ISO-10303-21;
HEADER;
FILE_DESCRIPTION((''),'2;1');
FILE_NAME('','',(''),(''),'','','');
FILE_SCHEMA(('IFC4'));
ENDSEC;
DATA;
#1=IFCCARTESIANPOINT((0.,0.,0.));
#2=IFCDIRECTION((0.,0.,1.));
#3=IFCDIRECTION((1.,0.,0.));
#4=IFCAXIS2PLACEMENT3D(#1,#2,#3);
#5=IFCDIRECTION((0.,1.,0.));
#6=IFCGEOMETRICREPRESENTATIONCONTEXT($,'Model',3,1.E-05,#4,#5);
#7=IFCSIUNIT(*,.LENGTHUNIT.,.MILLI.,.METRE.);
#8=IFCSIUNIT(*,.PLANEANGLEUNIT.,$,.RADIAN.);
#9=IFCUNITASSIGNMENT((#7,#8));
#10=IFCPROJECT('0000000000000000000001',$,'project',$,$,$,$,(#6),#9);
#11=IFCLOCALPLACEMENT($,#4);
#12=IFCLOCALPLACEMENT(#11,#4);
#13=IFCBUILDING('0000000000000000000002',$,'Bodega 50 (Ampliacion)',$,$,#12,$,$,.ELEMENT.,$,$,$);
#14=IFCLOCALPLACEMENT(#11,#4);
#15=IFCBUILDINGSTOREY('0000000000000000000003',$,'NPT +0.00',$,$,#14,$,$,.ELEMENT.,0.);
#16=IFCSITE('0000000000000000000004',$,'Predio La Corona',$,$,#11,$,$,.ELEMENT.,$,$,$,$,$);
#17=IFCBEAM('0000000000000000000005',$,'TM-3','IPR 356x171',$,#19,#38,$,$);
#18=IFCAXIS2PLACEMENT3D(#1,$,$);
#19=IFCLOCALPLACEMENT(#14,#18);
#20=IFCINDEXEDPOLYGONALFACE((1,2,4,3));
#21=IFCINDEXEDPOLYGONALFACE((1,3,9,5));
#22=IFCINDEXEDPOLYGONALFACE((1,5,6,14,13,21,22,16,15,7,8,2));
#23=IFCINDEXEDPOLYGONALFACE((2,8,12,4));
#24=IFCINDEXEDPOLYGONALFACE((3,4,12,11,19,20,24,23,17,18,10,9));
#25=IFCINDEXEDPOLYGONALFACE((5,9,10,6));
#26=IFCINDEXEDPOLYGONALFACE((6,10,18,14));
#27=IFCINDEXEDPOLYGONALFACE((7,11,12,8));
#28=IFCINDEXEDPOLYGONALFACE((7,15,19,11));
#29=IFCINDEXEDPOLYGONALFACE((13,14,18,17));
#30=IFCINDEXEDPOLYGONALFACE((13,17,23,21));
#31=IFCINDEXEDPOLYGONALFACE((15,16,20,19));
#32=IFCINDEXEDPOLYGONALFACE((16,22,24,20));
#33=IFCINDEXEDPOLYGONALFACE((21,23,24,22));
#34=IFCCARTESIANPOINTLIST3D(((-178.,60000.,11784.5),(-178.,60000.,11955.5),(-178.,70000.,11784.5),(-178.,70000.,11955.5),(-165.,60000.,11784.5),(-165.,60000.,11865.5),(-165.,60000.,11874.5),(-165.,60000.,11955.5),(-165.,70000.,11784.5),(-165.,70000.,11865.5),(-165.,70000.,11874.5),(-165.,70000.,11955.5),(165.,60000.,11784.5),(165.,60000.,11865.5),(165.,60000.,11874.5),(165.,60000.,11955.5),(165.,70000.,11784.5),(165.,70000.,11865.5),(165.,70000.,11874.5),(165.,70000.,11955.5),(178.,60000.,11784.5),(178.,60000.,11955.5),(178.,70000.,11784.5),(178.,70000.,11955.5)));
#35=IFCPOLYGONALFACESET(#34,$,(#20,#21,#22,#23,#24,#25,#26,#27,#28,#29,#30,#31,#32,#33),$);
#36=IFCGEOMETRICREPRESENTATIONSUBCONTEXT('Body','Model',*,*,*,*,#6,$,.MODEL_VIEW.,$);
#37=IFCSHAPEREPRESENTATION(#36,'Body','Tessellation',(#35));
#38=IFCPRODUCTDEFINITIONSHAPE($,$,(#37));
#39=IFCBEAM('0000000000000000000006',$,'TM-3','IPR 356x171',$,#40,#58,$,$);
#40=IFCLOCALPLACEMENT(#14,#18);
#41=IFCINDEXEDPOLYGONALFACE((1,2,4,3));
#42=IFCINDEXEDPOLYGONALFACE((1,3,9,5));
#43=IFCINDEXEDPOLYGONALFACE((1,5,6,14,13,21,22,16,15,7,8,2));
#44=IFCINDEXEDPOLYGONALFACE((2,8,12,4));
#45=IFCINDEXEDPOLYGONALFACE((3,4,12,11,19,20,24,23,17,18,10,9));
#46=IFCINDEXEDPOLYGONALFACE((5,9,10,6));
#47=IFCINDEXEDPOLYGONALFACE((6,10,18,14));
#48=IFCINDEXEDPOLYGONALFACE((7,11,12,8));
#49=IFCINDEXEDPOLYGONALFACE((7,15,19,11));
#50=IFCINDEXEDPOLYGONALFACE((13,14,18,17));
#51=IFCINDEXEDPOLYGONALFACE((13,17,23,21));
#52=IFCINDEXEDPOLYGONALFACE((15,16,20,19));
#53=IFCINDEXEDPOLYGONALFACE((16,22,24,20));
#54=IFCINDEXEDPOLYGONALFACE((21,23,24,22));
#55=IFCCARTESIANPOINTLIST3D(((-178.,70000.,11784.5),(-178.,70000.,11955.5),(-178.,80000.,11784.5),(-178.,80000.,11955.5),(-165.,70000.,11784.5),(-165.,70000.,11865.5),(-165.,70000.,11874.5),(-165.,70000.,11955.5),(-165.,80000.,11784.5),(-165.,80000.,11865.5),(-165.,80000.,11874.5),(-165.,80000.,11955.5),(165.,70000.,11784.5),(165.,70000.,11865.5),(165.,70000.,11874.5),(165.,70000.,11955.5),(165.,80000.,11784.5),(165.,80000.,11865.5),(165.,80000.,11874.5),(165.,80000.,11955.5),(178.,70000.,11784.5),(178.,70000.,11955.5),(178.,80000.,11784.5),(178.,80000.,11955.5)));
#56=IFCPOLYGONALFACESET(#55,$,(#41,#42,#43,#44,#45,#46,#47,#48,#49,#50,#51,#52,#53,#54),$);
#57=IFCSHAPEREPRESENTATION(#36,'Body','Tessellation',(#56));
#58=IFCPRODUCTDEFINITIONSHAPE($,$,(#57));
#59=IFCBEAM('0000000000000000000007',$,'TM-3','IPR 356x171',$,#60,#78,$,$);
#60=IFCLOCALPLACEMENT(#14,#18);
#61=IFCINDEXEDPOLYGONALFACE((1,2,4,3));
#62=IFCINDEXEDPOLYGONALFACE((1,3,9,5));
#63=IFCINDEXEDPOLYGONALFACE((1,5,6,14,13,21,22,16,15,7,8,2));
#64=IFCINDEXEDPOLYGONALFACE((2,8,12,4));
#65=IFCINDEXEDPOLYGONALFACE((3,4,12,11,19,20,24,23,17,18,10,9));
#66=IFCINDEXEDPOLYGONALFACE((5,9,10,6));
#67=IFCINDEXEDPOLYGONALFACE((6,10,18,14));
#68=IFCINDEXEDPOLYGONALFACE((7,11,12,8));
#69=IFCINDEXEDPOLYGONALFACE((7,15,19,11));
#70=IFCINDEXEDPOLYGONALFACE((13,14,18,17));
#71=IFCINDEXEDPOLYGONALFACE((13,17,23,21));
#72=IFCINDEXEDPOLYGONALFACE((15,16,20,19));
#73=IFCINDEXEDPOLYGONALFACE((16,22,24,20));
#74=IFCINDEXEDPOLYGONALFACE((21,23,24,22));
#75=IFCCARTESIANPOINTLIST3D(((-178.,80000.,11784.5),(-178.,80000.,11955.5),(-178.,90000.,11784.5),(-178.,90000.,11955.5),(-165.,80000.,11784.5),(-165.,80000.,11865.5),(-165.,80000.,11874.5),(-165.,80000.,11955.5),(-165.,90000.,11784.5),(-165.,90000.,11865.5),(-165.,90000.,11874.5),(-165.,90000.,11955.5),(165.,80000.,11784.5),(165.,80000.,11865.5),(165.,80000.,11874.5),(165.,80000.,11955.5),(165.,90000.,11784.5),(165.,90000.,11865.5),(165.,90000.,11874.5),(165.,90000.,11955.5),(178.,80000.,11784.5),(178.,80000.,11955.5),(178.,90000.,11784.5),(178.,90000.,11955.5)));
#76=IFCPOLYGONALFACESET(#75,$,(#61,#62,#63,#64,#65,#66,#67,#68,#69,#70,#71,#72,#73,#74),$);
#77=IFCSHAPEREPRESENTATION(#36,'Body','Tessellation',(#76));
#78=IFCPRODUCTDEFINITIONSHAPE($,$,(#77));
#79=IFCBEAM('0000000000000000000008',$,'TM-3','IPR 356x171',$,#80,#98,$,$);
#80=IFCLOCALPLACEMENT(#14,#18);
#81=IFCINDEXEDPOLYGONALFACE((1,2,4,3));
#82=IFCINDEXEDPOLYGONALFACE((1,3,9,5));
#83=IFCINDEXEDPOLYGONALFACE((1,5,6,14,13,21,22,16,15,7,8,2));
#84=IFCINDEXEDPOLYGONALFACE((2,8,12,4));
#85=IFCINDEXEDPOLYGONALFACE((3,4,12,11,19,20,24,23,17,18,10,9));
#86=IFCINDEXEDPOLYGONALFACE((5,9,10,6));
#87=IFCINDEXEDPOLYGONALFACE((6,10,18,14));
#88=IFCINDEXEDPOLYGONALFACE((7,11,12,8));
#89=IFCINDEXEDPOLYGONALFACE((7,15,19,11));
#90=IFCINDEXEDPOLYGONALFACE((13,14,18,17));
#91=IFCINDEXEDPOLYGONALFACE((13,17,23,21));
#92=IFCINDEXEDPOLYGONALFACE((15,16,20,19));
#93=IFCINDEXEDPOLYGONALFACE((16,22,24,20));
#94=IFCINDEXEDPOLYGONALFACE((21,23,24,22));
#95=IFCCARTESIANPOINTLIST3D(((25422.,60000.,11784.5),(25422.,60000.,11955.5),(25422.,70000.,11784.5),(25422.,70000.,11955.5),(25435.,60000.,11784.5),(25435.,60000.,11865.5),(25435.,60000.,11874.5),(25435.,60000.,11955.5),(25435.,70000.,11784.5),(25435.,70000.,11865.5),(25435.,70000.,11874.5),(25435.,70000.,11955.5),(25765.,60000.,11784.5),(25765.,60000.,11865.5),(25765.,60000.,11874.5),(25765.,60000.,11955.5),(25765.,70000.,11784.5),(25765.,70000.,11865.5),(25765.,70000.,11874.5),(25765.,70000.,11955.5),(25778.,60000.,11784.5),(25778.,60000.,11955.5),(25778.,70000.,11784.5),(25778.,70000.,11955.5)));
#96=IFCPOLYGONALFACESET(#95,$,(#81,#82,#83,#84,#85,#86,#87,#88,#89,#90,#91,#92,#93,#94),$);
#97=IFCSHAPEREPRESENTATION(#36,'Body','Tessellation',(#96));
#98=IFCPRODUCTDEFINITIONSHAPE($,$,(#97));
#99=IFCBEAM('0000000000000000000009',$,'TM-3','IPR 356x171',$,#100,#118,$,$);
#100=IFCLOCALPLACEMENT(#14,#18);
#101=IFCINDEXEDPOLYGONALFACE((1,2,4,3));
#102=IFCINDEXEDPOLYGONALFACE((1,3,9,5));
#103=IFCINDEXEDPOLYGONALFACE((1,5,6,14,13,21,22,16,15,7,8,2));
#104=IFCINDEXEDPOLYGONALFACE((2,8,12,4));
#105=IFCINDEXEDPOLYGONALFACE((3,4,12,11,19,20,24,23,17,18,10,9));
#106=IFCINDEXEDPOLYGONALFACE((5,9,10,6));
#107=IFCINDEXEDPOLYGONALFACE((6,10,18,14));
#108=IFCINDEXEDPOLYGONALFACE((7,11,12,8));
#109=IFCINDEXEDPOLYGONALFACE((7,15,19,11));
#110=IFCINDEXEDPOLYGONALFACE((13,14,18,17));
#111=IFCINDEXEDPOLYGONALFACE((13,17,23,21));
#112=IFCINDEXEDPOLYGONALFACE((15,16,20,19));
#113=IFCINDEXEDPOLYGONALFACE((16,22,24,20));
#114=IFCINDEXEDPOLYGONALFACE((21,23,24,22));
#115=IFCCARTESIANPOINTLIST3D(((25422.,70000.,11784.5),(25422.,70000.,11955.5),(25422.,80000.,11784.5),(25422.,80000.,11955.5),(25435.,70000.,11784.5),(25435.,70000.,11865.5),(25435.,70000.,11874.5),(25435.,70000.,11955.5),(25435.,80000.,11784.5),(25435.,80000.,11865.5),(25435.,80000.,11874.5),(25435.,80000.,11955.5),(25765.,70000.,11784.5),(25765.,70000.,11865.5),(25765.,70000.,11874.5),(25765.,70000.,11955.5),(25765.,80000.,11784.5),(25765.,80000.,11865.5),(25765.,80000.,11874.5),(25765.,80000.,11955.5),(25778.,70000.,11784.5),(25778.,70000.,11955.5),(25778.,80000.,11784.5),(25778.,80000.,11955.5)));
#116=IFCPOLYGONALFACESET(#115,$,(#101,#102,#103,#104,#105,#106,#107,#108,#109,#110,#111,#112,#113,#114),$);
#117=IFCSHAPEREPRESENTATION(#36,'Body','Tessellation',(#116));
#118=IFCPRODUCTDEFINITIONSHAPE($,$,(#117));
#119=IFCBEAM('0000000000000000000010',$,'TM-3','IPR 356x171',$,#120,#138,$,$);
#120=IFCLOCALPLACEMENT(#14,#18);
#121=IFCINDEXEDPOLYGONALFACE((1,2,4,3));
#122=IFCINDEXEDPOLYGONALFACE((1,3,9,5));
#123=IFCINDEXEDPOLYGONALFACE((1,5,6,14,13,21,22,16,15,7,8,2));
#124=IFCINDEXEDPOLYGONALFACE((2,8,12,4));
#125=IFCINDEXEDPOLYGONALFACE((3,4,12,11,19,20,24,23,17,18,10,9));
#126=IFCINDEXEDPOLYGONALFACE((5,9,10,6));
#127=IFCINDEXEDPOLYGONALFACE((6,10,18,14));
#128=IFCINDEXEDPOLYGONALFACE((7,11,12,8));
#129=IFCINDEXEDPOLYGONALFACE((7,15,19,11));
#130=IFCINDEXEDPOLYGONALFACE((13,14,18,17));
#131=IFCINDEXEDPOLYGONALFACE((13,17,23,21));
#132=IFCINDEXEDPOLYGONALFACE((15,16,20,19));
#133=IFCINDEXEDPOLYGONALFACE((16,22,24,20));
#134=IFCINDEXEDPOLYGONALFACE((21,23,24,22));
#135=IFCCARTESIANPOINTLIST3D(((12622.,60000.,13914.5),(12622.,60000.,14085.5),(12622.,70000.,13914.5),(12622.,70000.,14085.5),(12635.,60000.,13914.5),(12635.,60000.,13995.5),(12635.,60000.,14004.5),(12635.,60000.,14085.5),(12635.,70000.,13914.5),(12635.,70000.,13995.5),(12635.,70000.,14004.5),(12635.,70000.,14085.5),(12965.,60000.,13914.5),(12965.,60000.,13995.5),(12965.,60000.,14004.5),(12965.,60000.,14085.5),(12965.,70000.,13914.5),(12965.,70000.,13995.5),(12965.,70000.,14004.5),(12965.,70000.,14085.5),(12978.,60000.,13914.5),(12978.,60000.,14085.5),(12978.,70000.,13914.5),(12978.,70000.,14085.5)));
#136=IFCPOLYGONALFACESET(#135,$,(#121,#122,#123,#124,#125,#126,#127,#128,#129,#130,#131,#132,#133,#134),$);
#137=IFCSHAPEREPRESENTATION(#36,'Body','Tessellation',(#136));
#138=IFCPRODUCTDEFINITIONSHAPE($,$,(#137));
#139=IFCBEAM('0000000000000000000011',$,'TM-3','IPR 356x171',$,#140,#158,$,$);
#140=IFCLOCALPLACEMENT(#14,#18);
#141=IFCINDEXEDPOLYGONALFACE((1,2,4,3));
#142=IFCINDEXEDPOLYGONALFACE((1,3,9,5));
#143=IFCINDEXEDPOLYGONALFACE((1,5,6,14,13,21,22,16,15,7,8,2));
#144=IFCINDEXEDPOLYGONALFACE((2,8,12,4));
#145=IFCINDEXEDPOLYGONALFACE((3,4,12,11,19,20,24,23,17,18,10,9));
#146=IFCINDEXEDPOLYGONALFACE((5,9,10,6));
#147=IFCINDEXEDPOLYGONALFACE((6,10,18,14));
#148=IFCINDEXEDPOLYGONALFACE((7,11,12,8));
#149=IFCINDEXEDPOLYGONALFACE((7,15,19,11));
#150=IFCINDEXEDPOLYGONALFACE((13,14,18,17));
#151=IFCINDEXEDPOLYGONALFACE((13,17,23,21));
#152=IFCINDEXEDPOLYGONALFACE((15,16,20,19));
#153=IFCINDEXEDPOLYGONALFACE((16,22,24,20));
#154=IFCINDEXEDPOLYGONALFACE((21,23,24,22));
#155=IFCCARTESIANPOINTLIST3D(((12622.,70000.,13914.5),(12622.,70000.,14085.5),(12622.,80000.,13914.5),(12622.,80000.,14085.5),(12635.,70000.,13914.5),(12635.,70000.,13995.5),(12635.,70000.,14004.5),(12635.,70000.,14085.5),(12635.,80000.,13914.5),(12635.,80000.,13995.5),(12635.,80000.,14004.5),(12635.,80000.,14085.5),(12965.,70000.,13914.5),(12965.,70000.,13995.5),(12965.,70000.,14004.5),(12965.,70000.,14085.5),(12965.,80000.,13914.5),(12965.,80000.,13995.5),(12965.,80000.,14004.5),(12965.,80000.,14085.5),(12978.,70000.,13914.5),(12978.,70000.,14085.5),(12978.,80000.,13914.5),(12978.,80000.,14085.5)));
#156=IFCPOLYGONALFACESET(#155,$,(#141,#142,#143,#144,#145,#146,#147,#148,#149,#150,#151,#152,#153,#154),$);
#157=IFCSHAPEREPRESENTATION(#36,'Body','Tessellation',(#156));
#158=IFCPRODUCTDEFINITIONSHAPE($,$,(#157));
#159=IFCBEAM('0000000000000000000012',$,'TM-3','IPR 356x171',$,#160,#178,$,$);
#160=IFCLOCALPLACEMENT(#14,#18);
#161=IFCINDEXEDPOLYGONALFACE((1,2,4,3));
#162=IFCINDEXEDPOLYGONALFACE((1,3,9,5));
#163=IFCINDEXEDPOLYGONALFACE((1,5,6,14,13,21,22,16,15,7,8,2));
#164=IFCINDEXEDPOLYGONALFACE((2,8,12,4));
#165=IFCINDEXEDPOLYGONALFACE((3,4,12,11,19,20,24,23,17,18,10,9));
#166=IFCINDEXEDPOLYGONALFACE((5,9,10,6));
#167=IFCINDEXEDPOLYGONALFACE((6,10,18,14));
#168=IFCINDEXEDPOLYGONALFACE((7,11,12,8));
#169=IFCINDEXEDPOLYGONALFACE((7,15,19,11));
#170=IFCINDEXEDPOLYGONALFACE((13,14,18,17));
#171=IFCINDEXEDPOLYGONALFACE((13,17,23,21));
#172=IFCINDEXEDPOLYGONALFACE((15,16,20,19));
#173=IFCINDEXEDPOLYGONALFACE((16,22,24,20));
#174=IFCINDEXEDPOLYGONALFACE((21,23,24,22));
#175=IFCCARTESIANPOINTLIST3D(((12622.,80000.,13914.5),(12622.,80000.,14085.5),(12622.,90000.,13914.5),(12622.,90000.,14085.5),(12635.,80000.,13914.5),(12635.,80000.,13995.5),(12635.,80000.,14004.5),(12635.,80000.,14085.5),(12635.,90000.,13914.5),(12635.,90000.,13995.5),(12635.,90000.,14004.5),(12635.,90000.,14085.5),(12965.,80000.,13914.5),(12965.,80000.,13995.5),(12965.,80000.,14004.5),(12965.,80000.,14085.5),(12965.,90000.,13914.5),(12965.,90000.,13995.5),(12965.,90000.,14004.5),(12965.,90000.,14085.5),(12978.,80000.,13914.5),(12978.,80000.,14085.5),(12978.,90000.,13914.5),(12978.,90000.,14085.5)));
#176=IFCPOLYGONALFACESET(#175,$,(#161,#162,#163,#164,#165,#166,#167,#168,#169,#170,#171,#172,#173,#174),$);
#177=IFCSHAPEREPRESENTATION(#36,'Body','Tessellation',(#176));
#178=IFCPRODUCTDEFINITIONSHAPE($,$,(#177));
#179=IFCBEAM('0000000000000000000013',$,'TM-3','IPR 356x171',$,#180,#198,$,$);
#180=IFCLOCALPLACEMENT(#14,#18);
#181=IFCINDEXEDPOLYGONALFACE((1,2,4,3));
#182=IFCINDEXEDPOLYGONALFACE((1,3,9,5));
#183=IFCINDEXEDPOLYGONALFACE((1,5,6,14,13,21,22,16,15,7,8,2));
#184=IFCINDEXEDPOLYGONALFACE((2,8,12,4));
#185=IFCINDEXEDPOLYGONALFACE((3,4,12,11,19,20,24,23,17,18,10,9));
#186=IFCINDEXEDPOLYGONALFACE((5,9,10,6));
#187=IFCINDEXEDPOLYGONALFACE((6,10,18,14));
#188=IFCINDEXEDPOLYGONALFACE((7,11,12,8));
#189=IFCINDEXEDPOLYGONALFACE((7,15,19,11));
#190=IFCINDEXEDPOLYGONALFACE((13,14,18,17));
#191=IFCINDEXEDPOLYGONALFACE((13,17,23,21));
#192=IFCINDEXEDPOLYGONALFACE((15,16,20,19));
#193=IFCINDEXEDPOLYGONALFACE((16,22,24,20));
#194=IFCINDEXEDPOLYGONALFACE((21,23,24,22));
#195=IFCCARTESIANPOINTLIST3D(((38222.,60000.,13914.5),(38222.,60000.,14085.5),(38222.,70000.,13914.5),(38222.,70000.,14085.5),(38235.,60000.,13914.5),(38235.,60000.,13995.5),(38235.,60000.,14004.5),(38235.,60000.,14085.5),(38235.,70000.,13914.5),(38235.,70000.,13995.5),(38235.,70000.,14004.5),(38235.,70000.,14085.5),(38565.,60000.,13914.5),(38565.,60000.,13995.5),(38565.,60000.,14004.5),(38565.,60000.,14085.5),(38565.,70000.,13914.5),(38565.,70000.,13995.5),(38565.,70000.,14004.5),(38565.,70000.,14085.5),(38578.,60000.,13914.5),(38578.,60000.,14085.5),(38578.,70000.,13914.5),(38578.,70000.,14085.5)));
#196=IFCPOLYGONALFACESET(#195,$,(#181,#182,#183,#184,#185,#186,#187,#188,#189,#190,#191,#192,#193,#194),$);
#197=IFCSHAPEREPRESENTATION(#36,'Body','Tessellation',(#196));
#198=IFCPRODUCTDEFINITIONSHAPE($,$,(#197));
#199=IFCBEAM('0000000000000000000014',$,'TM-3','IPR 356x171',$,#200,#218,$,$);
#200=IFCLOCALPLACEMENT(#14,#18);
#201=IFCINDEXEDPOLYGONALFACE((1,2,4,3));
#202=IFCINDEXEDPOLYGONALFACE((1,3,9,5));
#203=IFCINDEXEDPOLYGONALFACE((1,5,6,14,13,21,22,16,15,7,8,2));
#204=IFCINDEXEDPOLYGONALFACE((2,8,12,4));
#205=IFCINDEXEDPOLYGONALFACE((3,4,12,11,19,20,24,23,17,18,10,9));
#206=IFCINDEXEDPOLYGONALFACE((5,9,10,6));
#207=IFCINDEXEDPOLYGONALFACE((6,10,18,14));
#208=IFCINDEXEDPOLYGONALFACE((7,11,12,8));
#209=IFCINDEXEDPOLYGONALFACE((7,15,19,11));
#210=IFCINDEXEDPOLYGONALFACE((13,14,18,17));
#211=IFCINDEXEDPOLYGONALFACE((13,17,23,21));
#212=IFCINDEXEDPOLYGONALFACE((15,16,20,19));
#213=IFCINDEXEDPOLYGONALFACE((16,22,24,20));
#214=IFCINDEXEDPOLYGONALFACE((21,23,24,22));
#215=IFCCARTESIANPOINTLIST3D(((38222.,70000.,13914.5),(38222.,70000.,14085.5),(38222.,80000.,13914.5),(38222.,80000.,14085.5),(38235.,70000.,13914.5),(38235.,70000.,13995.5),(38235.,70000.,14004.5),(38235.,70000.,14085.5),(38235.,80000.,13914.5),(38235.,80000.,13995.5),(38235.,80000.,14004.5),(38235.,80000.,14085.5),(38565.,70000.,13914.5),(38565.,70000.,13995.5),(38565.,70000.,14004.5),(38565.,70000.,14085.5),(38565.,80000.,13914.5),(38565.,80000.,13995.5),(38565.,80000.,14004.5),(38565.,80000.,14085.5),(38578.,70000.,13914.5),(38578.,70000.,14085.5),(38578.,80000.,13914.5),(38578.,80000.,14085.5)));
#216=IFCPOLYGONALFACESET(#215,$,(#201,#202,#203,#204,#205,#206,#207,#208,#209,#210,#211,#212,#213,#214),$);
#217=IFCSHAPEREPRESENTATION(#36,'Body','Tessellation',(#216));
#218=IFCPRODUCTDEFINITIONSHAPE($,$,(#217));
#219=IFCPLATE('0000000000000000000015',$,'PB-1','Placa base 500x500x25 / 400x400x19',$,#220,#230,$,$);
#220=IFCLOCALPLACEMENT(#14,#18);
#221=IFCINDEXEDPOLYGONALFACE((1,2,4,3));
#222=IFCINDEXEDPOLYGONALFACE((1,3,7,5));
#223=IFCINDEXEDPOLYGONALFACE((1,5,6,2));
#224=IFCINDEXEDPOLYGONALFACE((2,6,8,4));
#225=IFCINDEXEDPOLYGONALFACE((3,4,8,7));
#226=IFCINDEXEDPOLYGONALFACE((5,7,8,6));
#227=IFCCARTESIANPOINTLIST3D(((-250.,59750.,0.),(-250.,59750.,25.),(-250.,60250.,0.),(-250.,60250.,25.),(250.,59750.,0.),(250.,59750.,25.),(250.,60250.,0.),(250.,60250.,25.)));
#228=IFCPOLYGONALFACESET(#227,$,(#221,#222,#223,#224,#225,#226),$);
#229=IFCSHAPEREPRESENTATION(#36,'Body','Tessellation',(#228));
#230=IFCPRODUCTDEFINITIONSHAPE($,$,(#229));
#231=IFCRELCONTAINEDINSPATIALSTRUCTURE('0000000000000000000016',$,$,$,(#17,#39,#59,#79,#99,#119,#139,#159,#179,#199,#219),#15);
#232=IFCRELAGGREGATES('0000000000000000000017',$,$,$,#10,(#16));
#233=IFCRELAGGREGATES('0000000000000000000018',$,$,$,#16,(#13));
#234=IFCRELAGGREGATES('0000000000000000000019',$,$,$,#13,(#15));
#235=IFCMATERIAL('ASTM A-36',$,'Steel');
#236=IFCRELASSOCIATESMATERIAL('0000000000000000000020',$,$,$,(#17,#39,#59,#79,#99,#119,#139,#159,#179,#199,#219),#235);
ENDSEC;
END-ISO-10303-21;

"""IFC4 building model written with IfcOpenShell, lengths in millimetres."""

from ifc_helpers import new_model, si_unit, direction, frame, origin_with_axes, origin_2d, place, context, subcontext, project, spatial, rectangle, i_section, extrude, material, element, save


model = new_model("IFC4")

# Units and contexts
model_context = context("Model", 3, precision=1e-05, world=origin_with_axes(), true_north=direction((0.0, 1.0, 0.0)))
body_context = subcontext(model_context, "Body", "Model", "MODEL_VIEW")
ifc_project = project(units=[si_unit("LENGTHUNIT", "METRE", prefix="MILLI"), si_unit("PLANEANGLEUNIT", "RADIAN")], contexts=[model_context])

# Site, building, storey
site_placement = place(None, origin_with_axes())
site = spatial("IfcSite", under=ifc_project, at=site_placement, Name="Predio La Corona", CompositionType="ELEMENT")
building_placement = place(site_placement, origin_with_axes())
building = spatial("IfcBuilding", under=site, at=building_placement, Name="Bodega 50 (Ampliacion)", CompositionType="ELEMENT")
storey_placement = place(site_placement, origin_with_axes())
storey = spatial("IfcBuildingStorey", under=building, at=storey_placement, Name="NPT +0.00", CompositionType="ELEMENT", Elevation=0.0)

# Shared definitions
ifc_material = material(Name="ASTM A-36", Category="Steel")

# Beams
for number, where, z_axis, x_axis, name in (
    (1, (0.0, 60000.0, 11870.0), (0.0, 1.0, 0.0), (0.0, 0.0, 1.0), "TM-3"),
    (2, (0.0, 70000.0, 11870.0), (0.0, 1.0, 0.0), (0.0, 0.0, 1.0), "TM-3"),
    (3, (0.0, 80000.0, 11870.0), (0.0, 1.0, 0.0), (0.0, 0.0, 1.0), "TM-3"),
    (4, (25600.0, 60000.0, 11870.0), (0.0, 1.0, 0.0), (0.0, 0.0, 1.0), "TM-3"),
    (5, (25600.0, 70000.0, 11870.0), (0.0, 1.0, 0.0), (0.0, 0.0, 1.0), "TM-3"),
    (6, (12800.0, 60000.0, 14000.0), (0.0, 1.0, 0.0), (0.0, 0.0, 1.0), "TM-3"),
    (7, (12800.0, 70000.0, 14000.0), (0.0, 1.0, 0.0), (0.0, 0.0, 1.0), "TM-3"),
    (8, (12800.0, 80000.0, 14000.0), (0.0, 1.0, 0.0), (0.0, 0.0, 1.0), "TM-3"),
    (9, (38400.0, 60000.0, 14000.0), (0.0, 1.0, 0.0), (0.0, 0.0, 1.0), "TM-3"),
    (10, (38400.0, 70000.0, 14000.0), (0.0, 1.0, 0.0), (0.0, 0.0, 1.0), "TM-3"),
):
    element("IfcBeam", number, at=place(storey_placement, frame(where, z_axis=z_axis, x_axis=x_axis)), inside=storey, material=ifc_material, Name=name, Description="IPR 356x171", context=body_context, shape_type="SweptSolid", body=[
        extrude(i_section(OverallWidth=171.0, OverallDepth=356.0, WebThickness=9.0, FlangeThickness=13.0, at=origin_2d()), origin_with_axes(), (0.0, 0.0, 1.0), 10000.0),
    ])

# Plate
for number, where, z_axis, x_axis, name in (
    (11, (0.0, 60000.0, 0.0), (0.0, 0.0, 1.0), (1.0, 0.0, 0.0), "PB-1"),
):
    element("IfcPlate", number, at=place(storey_placement, frame(where, z_axis=z_axis, x_axis=x_axis)), inside=storey, material=ifc_material, Name=name, Description="Placa base 500x500x25 / 400x400x19", context=body_context, shape_type="SweptSolid", body=[
        extrude(rectangle(XDim=500.0, YDim=500.0, at=origin_2d()), origin_with_axes(), (0.0, 0.0, 1.0), 25.0),
    ])

save(model, "model.ifc")
